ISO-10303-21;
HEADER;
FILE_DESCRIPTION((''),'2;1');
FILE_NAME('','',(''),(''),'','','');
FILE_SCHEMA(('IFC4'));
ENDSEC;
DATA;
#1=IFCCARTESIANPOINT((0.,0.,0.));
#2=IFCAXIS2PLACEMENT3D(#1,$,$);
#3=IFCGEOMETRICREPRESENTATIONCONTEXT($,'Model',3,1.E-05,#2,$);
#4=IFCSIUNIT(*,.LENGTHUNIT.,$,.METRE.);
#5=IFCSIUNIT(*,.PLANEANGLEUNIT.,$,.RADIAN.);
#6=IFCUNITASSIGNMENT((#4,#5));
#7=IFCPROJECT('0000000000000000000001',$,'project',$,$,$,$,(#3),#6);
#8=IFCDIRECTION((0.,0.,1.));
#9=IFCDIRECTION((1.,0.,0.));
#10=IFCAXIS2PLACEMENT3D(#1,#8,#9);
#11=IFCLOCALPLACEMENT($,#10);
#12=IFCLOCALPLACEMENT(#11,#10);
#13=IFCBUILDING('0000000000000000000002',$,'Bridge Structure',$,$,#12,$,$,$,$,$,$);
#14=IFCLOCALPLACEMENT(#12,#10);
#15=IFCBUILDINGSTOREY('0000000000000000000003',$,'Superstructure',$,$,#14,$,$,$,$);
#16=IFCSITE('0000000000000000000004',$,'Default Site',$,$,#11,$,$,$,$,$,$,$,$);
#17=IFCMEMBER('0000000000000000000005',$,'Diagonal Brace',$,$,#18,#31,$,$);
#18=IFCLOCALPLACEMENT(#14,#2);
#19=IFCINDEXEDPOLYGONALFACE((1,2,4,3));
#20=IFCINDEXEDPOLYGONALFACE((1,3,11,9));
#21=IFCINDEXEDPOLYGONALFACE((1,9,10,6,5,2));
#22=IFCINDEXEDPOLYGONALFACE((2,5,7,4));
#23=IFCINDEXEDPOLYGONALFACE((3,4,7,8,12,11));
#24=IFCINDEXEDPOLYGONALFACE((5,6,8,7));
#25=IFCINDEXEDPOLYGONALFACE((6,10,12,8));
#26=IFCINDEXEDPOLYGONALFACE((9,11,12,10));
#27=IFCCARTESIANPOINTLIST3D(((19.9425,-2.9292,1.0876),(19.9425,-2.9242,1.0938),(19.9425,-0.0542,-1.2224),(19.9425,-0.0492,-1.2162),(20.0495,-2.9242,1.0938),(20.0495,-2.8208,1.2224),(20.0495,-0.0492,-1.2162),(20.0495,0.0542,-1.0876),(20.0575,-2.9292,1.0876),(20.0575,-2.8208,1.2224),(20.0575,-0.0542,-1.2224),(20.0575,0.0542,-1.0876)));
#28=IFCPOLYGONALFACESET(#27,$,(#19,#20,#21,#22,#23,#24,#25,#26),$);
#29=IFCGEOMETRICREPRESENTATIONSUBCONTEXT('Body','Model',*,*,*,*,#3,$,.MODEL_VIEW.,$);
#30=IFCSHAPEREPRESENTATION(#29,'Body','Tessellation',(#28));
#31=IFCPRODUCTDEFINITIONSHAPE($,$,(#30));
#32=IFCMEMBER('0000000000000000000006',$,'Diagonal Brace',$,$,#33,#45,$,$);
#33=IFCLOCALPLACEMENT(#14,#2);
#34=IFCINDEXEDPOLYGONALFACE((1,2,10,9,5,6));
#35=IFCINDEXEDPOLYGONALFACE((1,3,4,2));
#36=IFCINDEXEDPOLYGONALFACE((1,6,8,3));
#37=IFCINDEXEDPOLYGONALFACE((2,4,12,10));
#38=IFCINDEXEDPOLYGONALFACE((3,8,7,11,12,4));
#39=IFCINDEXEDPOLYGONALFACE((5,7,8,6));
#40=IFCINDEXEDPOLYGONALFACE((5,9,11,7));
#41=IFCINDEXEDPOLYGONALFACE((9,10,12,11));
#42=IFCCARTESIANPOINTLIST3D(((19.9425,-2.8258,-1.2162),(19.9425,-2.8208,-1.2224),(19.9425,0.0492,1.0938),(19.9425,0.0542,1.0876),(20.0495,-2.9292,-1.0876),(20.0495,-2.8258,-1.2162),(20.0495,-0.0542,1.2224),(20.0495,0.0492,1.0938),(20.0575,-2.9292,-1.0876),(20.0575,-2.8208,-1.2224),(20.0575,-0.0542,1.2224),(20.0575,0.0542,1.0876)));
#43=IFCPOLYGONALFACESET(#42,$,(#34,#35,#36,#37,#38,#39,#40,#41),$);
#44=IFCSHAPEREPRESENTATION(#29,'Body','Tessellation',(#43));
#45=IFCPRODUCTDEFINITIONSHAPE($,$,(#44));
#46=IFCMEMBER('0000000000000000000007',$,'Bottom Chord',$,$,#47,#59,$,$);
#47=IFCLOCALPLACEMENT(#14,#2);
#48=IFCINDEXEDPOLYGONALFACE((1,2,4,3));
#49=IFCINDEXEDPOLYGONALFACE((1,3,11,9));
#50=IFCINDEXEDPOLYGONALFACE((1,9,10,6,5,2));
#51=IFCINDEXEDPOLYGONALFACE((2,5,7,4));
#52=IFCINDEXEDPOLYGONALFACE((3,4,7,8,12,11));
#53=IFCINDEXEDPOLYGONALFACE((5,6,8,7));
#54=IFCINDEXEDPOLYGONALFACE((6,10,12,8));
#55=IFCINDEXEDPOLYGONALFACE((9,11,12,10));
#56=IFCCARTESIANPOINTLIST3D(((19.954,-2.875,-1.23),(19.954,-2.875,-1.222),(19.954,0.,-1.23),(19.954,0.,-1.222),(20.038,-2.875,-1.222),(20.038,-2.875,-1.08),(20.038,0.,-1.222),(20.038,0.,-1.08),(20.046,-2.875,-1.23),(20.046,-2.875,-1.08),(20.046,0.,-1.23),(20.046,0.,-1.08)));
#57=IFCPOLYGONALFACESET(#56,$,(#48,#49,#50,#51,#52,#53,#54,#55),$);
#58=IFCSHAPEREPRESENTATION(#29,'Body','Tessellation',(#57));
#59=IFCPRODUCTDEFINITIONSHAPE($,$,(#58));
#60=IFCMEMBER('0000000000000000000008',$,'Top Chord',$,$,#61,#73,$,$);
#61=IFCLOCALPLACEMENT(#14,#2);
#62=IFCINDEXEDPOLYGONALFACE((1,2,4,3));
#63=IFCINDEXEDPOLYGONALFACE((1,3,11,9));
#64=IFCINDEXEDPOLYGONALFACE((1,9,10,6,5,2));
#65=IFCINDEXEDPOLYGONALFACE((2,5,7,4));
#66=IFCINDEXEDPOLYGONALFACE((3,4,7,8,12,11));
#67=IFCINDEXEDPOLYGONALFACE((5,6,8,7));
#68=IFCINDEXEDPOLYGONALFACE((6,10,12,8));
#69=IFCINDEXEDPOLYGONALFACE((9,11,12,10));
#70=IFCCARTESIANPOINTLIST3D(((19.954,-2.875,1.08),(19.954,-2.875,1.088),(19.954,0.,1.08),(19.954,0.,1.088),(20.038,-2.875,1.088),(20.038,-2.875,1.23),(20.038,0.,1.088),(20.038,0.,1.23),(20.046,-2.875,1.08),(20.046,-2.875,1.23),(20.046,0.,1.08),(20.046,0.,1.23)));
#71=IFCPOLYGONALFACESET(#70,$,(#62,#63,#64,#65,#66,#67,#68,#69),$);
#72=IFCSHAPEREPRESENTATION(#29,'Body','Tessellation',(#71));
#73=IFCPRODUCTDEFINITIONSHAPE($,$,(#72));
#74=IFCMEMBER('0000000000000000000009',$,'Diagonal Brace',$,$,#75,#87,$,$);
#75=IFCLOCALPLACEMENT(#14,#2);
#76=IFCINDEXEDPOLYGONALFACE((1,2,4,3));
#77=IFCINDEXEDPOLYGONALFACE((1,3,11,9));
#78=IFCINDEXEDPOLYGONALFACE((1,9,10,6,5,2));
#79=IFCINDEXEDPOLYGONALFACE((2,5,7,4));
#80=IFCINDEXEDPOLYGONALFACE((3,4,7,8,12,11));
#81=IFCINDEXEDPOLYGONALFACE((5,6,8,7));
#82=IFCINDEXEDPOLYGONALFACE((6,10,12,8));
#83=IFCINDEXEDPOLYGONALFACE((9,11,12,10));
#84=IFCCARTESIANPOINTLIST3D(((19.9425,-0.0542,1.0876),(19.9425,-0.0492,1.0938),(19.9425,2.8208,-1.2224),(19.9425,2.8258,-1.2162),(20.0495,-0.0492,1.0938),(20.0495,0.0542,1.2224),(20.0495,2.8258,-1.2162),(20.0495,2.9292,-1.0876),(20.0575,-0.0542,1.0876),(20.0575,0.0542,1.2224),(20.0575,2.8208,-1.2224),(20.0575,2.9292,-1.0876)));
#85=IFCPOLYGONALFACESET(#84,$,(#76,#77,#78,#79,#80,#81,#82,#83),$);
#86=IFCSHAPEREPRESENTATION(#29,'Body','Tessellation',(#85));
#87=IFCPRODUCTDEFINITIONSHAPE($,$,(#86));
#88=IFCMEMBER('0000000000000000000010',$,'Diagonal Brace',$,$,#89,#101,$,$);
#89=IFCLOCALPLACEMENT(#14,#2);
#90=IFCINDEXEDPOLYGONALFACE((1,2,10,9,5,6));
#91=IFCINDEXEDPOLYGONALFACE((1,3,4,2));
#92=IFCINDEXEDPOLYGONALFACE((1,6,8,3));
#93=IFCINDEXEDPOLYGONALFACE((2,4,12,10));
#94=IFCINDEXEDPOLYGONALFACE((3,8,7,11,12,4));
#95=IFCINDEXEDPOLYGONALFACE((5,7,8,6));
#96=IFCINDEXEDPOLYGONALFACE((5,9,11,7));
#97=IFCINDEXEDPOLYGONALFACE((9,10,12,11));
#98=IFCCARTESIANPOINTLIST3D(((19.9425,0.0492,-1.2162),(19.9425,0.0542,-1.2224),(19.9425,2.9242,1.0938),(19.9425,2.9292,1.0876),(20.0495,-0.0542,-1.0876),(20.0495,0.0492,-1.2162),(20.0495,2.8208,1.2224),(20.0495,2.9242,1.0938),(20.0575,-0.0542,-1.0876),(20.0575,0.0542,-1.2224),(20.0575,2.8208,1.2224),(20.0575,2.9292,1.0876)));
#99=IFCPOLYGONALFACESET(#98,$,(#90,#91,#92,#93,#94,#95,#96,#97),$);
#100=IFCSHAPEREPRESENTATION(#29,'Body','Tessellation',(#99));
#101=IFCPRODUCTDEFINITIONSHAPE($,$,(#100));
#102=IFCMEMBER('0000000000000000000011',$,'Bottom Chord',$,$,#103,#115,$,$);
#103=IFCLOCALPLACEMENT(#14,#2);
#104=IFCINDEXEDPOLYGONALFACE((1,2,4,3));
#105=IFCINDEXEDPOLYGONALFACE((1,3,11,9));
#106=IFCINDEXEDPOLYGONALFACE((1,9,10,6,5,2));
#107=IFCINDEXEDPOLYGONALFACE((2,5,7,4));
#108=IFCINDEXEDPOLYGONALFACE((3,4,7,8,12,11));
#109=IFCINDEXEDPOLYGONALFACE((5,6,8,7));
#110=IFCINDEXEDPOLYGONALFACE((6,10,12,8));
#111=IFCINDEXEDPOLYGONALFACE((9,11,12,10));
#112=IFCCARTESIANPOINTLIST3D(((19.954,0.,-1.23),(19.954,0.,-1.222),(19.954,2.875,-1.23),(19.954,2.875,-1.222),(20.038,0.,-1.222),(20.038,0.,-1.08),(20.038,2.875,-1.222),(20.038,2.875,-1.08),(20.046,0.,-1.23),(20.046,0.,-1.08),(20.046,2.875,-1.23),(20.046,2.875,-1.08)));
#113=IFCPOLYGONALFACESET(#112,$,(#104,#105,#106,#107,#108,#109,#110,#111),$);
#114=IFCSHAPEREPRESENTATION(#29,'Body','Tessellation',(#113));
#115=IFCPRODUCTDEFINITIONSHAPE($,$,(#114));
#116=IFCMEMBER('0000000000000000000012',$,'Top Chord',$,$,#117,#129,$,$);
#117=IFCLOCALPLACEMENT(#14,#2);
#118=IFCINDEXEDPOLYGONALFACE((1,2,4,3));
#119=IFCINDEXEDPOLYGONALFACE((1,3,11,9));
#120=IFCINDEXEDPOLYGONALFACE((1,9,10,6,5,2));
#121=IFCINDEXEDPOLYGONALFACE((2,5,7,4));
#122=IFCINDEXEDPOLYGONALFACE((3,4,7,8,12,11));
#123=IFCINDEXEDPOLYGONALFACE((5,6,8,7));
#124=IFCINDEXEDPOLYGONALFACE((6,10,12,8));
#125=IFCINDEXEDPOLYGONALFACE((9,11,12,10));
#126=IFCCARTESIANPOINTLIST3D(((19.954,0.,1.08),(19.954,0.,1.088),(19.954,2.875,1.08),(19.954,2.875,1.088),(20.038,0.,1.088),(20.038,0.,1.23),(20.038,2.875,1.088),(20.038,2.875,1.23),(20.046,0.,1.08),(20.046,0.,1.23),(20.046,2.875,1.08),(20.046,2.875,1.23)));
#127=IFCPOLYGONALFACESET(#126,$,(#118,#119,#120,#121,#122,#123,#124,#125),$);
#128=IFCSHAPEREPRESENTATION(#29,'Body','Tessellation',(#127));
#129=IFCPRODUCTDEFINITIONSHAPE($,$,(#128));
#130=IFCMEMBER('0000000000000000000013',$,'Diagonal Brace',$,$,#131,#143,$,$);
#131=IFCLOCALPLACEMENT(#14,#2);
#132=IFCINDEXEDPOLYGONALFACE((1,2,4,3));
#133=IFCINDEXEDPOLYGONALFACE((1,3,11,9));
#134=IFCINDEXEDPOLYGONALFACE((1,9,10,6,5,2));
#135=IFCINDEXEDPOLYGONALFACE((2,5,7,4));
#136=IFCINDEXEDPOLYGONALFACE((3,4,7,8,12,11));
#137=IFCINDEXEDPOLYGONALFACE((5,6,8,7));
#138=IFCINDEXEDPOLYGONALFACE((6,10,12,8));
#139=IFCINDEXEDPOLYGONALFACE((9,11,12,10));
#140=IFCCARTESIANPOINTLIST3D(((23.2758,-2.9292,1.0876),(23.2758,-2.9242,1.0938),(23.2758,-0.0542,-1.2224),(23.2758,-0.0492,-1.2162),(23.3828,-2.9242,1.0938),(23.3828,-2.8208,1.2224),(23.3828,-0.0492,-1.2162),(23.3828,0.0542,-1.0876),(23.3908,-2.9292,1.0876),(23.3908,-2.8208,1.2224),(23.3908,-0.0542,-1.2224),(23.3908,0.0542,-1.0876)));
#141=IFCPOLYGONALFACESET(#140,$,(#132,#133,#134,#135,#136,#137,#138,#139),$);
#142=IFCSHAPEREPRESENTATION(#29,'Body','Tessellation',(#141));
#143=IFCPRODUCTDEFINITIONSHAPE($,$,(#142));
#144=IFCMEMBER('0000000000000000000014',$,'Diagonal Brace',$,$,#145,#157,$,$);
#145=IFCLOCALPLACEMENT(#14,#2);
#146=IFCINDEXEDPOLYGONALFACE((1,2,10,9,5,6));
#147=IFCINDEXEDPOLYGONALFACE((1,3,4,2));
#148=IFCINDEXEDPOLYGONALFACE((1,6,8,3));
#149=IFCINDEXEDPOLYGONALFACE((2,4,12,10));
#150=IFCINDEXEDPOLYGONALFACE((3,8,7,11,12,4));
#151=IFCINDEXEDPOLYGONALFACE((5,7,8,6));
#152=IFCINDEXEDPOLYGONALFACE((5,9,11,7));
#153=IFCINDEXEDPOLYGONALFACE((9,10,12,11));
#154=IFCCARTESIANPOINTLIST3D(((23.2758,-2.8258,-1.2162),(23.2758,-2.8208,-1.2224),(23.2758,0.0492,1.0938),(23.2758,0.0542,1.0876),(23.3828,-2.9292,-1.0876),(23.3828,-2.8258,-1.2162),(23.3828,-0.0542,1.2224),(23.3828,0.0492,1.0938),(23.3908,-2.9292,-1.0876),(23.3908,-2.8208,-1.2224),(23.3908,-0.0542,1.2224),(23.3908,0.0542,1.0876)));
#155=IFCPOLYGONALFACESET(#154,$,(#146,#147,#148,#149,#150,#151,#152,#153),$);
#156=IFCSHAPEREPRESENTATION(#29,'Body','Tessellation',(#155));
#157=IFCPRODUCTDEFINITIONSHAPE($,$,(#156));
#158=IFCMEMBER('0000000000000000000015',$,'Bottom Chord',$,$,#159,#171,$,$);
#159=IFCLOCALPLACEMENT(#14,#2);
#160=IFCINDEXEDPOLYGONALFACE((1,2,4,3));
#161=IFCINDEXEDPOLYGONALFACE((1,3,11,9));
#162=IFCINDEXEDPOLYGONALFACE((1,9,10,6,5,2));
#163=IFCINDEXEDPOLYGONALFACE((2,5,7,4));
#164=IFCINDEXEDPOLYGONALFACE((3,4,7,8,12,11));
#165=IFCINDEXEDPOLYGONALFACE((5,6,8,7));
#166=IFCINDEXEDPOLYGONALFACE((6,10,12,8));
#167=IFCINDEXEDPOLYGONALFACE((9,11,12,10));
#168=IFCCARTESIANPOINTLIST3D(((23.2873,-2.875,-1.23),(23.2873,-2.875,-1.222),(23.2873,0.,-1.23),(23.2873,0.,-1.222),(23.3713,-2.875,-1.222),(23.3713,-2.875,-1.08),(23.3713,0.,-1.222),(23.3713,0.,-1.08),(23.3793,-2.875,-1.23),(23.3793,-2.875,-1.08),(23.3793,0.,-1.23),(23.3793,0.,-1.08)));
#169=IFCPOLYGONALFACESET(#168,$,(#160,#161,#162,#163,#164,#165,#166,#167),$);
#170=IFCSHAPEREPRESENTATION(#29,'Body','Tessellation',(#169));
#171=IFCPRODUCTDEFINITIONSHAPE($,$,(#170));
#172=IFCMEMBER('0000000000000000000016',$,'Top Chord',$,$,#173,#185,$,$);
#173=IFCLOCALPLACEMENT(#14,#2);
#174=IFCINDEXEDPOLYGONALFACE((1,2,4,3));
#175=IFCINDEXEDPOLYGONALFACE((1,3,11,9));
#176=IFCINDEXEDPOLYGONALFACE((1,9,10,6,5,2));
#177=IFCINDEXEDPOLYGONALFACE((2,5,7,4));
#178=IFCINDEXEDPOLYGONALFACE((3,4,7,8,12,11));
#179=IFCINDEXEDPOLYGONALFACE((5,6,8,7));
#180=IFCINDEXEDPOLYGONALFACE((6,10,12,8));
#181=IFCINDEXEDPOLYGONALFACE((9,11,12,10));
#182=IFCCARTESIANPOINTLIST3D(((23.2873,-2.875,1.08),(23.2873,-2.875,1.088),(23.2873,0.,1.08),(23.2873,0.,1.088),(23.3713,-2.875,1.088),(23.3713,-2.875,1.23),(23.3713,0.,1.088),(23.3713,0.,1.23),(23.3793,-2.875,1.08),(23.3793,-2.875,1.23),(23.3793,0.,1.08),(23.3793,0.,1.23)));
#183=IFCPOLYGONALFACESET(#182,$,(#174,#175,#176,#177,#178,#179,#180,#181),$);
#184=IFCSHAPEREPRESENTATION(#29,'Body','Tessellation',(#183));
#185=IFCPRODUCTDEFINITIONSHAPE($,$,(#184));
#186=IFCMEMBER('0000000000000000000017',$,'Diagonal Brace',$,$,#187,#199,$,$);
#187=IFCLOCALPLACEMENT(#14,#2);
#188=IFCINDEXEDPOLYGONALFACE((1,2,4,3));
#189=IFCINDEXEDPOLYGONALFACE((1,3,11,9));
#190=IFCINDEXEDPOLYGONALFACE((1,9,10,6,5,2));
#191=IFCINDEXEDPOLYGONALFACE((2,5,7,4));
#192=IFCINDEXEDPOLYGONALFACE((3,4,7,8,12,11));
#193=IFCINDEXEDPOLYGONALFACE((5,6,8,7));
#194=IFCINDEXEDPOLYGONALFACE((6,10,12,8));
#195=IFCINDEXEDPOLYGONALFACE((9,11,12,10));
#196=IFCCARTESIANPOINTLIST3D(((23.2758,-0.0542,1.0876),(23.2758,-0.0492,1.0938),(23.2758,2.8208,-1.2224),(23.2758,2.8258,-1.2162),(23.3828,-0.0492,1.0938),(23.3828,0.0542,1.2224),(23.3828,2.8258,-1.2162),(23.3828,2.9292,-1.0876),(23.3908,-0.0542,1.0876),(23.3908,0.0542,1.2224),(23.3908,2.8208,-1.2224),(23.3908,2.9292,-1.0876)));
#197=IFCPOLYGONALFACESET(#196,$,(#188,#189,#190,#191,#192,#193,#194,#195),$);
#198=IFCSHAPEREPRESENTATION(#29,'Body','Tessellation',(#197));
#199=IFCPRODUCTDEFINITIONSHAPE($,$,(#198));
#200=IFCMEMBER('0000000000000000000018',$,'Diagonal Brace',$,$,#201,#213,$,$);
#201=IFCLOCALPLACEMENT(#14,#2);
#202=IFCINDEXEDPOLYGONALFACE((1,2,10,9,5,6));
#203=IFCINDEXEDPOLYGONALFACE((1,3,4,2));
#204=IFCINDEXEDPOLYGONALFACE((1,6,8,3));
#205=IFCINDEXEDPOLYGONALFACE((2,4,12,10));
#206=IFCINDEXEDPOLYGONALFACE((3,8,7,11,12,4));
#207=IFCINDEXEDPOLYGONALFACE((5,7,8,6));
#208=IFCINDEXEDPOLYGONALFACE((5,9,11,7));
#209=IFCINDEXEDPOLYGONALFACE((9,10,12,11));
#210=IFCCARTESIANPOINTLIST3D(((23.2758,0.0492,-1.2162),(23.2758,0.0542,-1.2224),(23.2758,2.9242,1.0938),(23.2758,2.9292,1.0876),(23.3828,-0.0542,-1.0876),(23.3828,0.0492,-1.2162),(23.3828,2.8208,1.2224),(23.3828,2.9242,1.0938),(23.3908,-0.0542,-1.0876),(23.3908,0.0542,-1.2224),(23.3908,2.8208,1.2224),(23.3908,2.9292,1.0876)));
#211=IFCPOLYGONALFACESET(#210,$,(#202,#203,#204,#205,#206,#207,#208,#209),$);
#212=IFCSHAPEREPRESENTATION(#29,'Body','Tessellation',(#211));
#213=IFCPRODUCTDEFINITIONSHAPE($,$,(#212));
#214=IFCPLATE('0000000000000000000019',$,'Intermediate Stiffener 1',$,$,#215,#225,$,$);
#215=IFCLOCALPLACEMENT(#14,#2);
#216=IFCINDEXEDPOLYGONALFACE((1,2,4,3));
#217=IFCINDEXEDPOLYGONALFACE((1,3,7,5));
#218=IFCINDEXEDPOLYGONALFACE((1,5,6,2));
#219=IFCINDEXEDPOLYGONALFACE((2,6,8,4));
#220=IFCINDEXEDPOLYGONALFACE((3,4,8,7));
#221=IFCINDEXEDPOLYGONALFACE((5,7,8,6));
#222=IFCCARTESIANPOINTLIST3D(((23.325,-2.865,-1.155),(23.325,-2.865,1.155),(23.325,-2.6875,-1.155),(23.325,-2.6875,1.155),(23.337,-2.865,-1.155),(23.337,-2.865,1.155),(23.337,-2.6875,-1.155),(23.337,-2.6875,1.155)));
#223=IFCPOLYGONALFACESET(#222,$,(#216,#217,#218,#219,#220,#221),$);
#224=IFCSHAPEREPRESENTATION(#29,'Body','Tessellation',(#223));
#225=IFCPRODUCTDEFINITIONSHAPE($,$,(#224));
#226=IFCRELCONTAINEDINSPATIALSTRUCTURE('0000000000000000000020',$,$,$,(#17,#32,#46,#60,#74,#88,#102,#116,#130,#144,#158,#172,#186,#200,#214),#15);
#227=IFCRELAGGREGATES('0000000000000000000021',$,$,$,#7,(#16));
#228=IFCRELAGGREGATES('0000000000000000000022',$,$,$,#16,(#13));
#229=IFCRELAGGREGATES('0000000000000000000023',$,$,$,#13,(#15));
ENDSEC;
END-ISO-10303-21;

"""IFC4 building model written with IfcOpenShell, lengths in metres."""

from ifc_helpers import new_model, si_unit, frame, origin, origin_with_axes, origin_2d_with_axis, place, context, subcontext, project, spatial, rectangle, l_section, extrude, element, save


model = new_model("IFC4")

# Units and contexts
model_context = context("Model", 3, precision=1e-05, world=origin())
body_context = subcontext(model_context, "Body", "Model", "MODEL_VIEW")
ifc_project = project(units=[si_unit("LENGTHUNIT", "METRE"), si_unit("PLANEANGLEUNIT", "RADIAN")], contexts=[model_context])

# Site, building, storey
site_placement = place(None, origin_with_axes())
site = spatial("IfcSite", under=ifc_project, at=site_placement, Name="Default Site")
building_placement = place(site_placement, origin_with_axes())
building = spatial("IfcBuilding", under=site, at=building_placement, Name="Bridge Structure")
storey_placement = place(building_placement, origin_with_axes())
storey = spatial("IfcBuildingStorey", under=building, at=storey_placement, Name="Superstructure")

# Members
for number, where, z_axis, x_axis, name in (
    (1, (20.0, -2.875, 1.155), (0.0, 0.779544, -0.626347), (-1.0, 0.0, 0.0), "Diagonal Brace"),
    (2, (20.0, -2.875, -1.155), (0.0, 0.779544, 0.626347), (-1.0, 0.0, 0.0), "Diagonal Brace"),
):
    element("IfcMember", number, at=place(storey_placement, frame(where, z_axis=z_axis, x_axis=x_axis)), inside=storey, Name=name, context=body_context, shape_type="SweptSolid", body=[
        extrude(l_section(Depth=0.173, Width=0.115, Thickness=0.008, at=origin_2d_with_axis()), origin_with_axes(), (0.0, 0.0, 1.0), 3.6881),
    ])
for number, where, z_axis, x_axis, name in (
    (3, (20.0, -2.875, -1.155), (0.0, 1.0, 0.0), (-1.0, 0.0, 0.0), "Bottom Chord"),
    (4, (20.0, -2.875, 1.155), (0.0, 1.0, 0.0), (-1.0, 0.0, 0.0), "Top Chord"),
):
    element("IfcMember", number, at=place(storey_placement, frame(where, z_axis=z_axis, x_axis=x_axis)), inside=storey, Name=name, context=body_context, shape_type="SweptSolid", body=[
        extrude(l_section(Depth=0.15, Width=0.092, Thickness=0.008, at=origin_2d_with_axis()), origin_with_axes(), (0.0, 0.0, 1.0), 2.875),
    ])
for number, where, z_axis, x_axis, name in (
    (5, (20.0, 0.0, 1.155), (0.0, 0.779544, -0.626347), (-1.0, 0.0, 0.0), "Diagonal Brace"),
    (6, (20.0, 0.0, -1.155), (0.0, 0.779544, 0.626347), (-1.0, 0.0, 0.0), "Diagonal Brace"),
):
    element("IfcMember", number, at=place(storey_placement, frame(where, z_axis=z_axis, x_axis=x_axis)), inside=storey, Name=name, context=body_context, shape_type="SweptSolid", body=[
        extrude(l_section(Depth=0.173, Width=0.115, Thickness=0.008, at=origin_2d_with_axis()), origin_with_axes(), (0.0, 0.0, 1.0), 3.6881),
    ])
for number, where, z_axis, x_axis, name in (
    (7, (20.0, 0.0, -1.155), (0.0, 1.0, 0.0), (-1.0, 0.0, 0.0), "Bottom Chord"),
    (8, (20.0, 0.0, 1.155), (0.0, 1.0, 0.0), (-1.0, 0.0, 0.0), "Top Chord"),
):
    element("IfcMember", number, at=place(storey_placement, frame(where, z_axis=z_axis, x_axis=x_axis)), inside=storey, Name=name, context=body_context, shape_type="SweptSolid", body=[
        extrude(l_section(Depth=0.15, Width=0.092, Thickness=0.008, at=origin_2d_with_axis()), origin_with_axes(), (0.0, 0.0, 1.0), 2.875),
    ])
for number, where, z_axis, x_axis, name in (
    (9, (23.3333, -2.875, 1.155), (0.0, 0.779544, -0.626347), (-1.0, 0.0, 0.0), "Diagonal Brace"),
    (10, (23.3333, -2.875, -1.155), (0.0, 0.779544, 0.626347), (-1.0, 0.0, 0.0), "Diagonal Brace"),
):
    element("IfcMember", number, at=place(storey_placement, frame(where, z_axis=z_axis, x_axis=x_axis)), inside=storey, Name=name, context=body_context, shape_type="SweptSolid", body=[
        extrude(l_section(Depth=0.173, Width=0.115, Thickness=0.008, at=origin_2d_with_axis()), origin_with_axes(), (0.0, 0.0, 1.0), 3.6881),
    ])
for number, where, z_axis, x_axis, name in (
    (11, (23.3333, -2.875, -1.155), (0.0, 1.0, 0.0), (-1.0, 0.0, 0.0), "Bottom Chord"),
    (12, (23.3333, -2.875, 1.155), (0.0, 1.0, 0.0), (-1.0, 0.0, 0.0), "Top Chord"),
):
    element("IfcMember", number, at=place(storey_placement, frame(where, z_axis=z_axis, x_axis=x_axis)), inside=storey, Name=name, context=body_context, shape_type="SweptSolid", body=[
        extrude(l_section(Depth=0.15, Width=0.092, Thickness=0.008, at=origin_2d_with_axis()), origin_with_axes(), (0.0, 0.0, 1.0), 2.875),
    ])
for number, where, z_axis, x_axis, name in (
    (13, (23.3333, 0.0, 1.155), (0.0, 0.779544, -0.626347), (-1.0, 0.0, 0.0), "Diagonal Brace"),
    (14, (23.3333, 0.0, -1.155), (0.0, 0.779544, 0.626347), (-1.0, 0.0, 0.0), "Diagonal Brace"),
):
    element("IfcMember", number, at=place(storey_placement, frame(where, z_axis=z_axis, x_axis=x_axis)), inside=storey, Name=name, context=body_context, shape_type="SweptSolid", body=[
        extrude(l_section(Depth=0.173, Width=0.115, Thickness=0.008, at=origin_2d_with_axis()), origin_with_axes(), (0.0, 0.0, 1.0), 3.6881),
    ])

# Plate
for number, where, z_axis, x_axis, name in (
    (15, (23.331, -2.7763, -1.155), (0.0, 0.0, 1.0), (1.0, 0.0, 0.0), "Intermediate Stiffener 1"),
):
    element("IfcPlate", number, at=place(storey_placement, frame(where, z_axis=z_axis, x_axis=x_axis)), inside=storey, Name=name, context=body_context, shape_type="SweptSolid", body=[
        extrude(rectangle(XDim=0.012, YDim=0.1775, at=origin_2d_with_axis()), origin_with_axes(), (0.0, 0.0, 1.0), 2.31),
    ])

save(model, "model.ifc")
